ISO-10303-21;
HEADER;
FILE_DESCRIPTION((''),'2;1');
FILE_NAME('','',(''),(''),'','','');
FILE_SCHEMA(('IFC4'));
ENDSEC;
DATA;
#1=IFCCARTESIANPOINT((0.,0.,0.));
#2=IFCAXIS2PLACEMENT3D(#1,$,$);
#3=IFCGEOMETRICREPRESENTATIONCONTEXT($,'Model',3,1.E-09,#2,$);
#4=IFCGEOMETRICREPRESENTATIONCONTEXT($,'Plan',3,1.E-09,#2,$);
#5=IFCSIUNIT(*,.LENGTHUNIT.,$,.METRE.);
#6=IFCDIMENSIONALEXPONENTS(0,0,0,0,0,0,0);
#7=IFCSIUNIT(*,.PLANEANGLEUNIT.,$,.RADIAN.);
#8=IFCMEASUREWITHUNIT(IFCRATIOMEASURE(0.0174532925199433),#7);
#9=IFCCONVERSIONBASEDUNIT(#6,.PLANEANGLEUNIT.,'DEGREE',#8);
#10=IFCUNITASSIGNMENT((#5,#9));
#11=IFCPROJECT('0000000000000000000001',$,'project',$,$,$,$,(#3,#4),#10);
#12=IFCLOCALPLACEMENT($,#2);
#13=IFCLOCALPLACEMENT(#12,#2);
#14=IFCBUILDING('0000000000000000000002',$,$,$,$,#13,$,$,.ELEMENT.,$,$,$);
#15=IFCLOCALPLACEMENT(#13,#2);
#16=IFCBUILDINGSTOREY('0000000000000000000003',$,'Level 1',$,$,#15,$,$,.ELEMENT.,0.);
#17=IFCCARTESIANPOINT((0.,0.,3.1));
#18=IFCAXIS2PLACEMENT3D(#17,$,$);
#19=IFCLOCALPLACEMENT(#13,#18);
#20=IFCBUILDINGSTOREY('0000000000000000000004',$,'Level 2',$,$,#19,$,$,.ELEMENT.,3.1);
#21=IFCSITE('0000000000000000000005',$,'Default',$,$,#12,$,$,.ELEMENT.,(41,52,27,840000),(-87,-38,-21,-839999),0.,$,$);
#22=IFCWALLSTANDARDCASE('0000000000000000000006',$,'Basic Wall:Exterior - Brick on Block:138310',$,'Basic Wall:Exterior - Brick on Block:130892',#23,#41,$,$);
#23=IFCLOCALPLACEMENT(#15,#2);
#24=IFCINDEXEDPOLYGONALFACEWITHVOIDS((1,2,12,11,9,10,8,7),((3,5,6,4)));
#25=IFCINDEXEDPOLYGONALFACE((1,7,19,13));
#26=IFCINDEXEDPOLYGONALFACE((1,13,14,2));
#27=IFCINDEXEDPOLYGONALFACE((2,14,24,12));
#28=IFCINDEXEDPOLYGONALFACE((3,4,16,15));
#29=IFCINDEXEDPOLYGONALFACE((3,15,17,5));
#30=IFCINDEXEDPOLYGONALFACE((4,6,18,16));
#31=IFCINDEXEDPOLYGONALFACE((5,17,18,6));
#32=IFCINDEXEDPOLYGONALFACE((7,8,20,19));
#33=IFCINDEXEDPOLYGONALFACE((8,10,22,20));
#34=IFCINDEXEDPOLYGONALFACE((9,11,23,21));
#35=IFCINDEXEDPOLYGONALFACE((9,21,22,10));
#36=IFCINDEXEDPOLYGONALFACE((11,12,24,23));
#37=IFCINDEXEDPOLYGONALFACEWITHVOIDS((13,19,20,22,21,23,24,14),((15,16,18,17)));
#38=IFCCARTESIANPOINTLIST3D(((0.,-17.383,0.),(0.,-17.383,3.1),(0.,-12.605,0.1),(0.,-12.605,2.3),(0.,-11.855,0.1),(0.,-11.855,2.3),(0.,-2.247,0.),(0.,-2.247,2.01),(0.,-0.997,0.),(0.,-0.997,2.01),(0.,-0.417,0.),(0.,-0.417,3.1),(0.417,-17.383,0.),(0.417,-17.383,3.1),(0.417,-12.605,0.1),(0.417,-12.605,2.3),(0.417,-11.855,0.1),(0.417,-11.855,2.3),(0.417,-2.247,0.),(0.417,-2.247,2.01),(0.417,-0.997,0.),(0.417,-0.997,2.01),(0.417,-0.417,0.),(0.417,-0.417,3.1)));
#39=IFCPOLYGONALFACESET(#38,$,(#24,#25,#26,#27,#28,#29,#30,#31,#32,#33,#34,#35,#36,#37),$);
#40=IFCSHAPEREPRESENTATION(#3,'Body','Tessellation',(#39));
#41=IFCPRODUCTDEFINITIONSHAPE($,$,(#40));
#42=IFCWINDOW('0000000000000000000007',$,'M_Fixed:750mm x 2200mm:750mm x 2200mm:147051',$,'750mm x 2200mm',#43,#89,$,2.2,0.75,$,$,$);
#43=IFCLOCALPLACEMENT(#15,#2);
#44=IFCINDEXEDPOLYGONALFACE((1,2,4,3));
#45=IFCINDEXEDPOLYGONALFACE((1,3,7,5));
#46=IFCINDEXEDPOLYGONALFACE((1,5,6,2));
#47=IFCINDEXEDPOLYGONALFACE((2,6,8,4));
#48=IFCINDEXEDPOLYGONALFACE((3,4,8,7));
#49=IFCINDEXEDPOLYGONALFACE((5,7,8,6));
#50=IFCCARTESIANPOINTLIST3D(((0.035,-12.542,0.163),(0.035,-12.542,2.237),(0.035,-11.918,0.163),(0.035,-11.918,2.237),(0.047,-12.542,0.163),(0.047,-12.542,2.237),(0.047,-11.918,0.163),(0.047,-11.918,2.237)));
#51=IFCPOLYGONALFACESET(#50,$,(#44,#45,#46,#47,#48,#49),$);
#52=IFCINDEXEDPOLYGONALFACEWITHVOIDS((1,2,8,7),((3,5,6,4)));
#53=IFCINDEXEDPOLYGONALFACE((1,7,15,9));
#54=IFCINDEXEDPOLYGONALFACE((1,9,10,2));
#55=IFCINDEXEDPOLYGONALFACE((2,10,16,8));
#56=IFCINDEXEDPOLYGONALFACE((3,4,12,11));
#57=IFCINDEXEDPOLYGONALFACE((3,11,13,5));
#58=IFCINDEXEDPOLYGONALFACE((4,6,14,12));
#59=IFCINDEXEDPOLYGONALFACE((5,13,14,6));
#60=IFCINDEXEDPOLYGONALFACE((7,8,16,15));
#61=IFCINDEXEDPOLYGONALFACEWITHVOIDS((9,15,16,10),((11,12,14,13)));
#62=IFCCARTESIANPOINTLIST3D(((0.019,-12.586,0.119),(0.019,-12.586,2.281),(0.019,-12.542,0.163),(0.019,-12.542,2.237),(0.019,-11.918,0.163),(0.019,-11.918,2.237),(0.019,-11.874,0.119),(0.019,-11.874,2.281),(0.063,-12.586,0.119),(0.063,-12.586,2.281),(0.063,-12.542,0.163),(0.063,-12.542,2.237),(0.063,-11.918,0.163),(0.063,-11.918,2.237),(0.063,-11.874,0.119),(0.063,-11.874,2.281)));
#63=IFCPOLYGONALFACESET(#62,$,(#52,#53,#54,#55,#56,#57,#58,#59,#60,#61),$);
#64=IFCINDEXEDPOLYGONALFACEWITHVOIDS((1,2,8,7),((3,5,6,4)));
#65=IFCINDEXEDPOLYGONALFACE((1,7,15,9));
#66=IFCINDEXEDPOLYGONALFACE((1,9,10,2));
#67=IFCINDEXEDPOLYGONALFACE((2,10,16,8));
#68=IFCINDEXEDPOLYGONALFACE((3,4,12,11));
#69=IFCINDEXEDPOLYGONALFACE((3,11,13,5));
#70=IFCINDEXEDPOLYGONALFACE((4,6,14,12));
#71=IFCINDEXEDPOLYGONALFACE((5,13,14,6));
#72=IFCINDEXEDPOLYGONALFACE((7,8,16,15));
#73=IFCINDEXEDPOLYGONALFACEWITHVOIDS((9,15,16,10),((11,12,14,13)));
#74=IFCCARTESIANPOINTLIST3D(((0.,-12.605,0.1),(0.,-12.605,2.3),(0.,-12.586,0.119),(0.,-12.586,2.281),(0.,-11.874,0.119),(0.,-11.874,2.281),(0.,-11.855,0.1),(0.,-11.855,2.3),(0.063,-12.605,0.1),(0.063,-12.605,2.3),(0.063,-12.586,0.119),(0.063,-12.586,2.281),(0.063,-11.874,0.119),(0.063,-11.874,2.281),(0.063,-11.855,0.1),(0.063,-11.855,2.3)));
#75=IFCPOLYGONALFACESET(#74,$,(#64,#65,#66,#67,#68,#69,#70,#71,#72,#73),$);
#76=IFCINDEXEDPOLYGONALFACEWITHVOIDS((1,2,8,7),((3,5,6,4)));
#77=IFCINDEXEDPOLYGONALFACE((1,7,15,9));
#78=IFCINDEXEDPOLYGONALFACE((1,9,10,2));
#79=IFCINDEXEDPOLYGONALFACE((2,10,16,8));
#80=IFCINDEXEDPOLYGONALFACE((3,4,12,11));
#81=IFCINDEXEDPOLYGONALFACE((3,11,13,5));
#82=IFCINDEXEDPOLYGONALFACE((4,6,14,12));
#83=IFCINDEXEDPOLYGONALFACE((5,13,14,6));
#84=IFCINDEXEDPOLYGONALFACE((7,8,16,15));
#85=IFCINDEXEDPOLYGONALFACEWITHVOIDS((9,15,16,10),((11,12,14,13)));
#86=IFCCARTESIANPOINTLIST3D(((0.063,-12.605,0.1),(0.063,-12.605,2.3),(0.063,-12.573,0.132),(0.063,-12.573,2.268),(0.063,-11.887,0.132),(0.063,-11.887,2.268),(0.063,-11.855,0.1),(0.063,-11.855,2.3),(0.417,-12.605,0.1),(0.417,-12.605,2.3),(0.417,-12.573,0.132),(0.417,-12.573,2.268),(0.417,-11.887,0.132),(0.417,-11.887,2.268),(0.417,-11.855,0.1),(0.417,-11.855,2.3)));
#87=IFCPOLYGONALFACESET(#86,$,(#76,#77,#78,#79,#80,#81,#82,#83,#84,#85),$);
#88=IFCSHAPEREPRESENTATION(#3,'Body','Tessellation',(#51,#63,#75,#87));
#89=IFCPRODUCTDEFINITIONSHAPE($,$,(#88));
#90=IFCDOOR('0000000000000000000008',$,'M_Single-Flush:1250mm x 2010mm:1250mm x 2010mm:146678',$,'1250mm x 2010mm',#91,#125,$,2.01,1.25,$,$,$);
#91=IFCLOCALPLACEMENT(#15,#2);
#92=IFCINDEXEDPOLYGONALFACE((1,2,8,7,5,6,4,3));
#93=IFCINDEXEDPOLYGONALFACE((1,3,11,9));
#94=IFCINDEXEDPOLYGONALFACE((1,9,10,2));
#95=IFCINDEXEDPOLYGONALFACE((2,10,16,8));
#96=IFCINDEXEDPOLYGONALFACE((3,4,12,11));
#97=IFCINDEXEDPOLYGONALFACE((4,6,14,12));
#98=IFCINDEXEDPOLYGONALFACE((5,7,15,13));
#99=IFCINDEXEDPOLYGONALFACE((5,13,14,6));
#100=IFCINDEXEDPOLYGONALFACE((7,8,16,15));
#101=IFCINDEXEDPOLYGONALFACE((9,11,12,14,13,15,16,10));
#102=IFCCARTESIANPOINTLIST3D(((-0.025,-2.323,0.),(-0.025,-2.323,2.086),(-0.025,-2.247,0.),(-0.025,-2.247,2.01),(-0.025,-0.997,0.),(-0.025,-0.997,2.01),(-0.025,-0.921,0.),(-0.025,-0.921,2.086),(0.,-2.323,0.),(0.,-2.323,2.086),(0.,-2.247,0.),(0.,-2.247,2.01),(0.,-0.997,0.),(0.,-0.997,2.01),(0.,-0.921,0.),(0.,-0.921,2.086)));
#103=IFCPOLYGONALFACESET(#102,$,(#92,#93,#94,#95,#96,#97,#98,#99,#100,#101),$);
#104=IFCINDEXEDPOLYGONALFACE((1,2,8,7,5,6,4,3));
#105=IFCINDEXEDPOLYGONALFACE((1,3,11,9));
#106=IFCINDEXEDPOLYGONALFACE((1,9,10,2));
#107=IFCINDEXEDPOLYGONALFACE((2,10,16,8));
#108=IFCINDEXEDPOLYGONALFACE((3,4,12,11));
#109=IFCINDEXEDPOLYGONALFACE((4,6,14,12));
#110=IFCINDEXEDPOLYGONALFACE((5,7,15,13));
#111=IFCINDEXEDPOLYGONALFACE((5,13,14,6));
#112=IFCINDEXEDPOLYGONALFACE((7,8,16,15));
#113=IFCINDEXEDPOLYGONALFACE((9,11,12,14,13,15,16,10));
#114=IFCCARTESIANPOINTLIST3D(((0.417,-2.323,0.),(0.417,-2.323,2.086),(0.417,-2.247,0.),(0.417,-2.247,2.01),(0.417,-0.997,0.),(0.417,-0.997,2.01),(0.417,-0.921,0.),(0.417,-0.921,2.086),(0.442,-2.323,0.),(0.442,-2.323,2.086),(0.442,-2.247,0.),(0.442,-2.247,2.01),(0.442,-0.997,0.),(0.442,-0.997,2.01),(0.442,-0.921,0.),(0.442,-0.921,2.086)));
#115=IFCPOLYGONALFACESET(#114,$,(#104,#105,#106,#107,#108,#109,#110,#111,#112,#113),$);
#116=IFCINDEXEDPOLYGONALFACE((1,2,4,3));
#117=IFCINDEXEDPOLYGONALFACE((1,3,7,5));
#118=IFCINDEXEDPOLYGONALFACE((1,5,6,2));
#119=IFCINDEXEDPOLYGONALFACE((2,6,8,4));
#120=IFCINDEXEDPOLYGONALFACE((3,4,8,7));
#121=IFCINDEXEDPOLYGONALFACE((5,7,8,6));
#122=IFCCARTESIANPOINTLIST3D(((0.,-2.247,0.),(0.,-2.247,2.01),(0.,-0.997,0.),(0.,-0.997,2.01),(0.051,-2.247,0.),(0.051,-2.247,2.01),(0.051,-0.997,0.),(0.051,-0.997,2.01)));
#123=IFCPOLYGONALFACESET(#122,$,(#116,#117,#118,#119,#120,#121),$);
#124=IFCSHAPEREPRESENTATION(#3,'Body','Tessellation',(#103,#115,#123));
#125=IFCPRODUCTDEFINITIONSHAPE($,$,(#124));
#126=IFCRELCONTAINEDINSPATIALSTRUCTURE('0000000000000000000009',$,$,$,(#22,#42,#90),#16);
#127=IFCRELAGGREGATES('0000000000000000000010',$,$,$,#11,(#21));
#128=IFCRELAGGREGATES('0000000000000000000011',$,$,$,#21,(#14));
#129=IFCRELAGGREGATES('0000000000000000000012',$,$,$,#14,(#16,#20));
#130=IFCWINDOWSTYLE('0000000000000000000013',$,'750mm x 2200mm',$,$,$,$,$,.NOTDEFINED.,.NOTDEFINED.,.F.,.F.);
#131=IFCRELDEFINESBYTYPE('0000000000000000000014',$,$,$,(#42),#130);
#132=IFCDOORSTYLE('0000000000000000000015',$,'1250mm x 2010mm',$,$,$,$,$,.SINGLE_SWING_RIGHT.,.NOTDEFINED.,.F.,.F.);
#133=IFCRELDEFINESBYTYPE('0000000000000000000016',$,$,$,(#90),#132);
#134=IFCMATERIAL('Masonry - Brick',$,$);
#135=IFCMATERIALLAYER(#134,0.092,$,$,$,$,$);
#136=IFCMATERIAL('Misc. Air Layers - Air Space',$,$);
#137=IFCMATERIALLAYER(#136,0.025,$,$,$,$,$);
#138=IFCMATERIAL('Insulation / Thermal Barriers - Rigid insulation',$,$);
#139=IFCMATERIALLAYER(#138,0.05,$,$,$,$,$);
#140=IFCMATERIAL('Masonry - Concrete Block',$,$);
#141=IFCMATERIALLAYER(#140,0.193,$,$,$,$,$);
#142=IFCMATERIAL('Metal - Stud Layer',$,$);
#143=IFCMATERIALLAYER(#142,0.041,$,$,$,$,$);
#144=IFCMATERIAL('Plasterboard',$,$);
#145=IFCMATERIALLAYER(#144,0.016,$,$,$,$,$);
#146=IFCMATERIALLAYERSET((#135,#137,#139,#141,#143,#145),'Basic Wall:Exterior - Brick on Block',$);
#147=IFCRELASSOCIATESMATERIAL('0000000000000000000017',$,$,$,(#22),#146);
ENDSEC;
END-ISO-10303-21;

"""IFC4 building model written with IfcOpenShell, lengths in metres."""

from ifc_helpers import new_model, entity, si_unit, converted_unit, frame, frame_2d, origin, origin_2d_with_axis, place, context, project, spatial, polyline, rectangle, outline, extrude, source, transform, mapped, material, layer, layer_set, layer_usage, type_object, type_shapes, element, fill, save


model = new_model("IFC4")

# Units and contexts
model_context = context("Model", 3, precision=1e-09, world=origin())
plan_context = context("Plan", 3, precision=1e-09, world=origin())
ifc_project = project(units=[si_unit("LENGTHUNIT", "METRE"), converted_unit("PLANEANGLEUNIT", "DEGREE", entity("IfcRatioMeasure", 0.0174532925199433), si_unit("PLANEANGLEUNIT", "RADIAN"), dimensions=[0, 0, 0, 0, 0, 0, 0])], contexts=[model_context, plan_context])

# Site, building, storey
site_placement = place(None, origin())
site = spatial("IfcSite", under=ifc_project, at=site_placement, Name="Default", CompositionType="ELEMENT", RefLatitude=(41, 52, 27, 840000), RefLongitude=(-87, -38, -21, -839999), RefElevation=0.0)
building_placement = place(site_placement, origin())
building = spatial("IfcBuilding", under=site, at=building_placement, CompositionType="ELEMENT")
storey_1_placement = place(building_placement, origin())
storey_1 = spatial("IfcBuildingStorey", under=building, at=storey_1_placement, Name="Level 1", CompositionType="ELEMENT", Elevation=0.0)

# Shared definitions
ifc_material_1 = material(Name="Metal - Stud Layer")
ifc_material_2 = material(Name="Plasterboard")
ifc_material_3 = material(Name="Masonry - Concrete Block")
ifc_material_4 = material(Name="Misc. Air Layers - Air Space")

# Wall, openings, window, door
ifc_material_5 = material(Name="Masonry - Brick")
ifc_layer_1 = layer(ifc_material_5, 0.092)
ifc_layer_2 = layer(ifc_material_4, 0.025)
ifc_material_6 = material(Name="Insulation / Thermal Barriers - Rigid insulation")
ifc_layer_3 = layer(ifc_material_6, 0.05)
ifc_layer_4 = layer(ifc_material_3, 0.193)
ifc_layer_5 = layer(ifc_material_1, 0.041)
ifc_layer_6 = layer(ifc_material_2, 0.016)
ifc_layer_set_1 = layer_set([ifc_layer_1, ifc_layer_2, ifc_layer_3, ifc_layer_4, ifc_layer_5, ifc_layer_6], Name="Basic Wall:Exterior - Brick on Block")
ifc_layer_usage_1 = layer_usage(ifc_layer_set_1, "AXIS2", "NEGATIVE", 0.2085)
wall_1_placement = place(storey_1_placement, frame((0.2085, -17.383, 0.0), z_axis=(0.0, 0.0, 1.0), x_axis=(0.0, 1.0, 0.0)))
wall_1 = element("IfcWallStandardCase", 1, at=wall_1_placement, inside=storey_1, material=ifc_layer_usage_1, Name="Basic Wall:Exterior - Brick on Block:138310", ObjectType="Basic Wall:Exterior - Brick on Block:130892", context=model_context, shape_type="SweptSolid", body=[
    extrude(rectangle(XDim=16.966, YDim=0.417, at=frame_2d((8.483, 0.0), x_axis=(-1.0, 0.0))), origin(), (0.0, 0.0, 1.0), 3.1),
])
opening_1_placement = place(wall_1_placement, frame((4.778, -0.2085, 0.1)))
opening_1 = element("IfcOpeningElement", 2, at=opening_1_placement, cuts=wall_1, ObjectType="Opening", context=model_context, shape_type="SweptSolid", body=[
    extrude(rectangle(XDim=2.2, YDim=0.75, at=frame_2d((1.1, 0.375), x_axis=(1.0, 0.0))), frame((0.0, 0.0, 0.0), z_axis=(0.0, 1.0, 0.0), x_axis=(0.0, 0.0, 1.0)), (0.0, 0.0, 1.0), 0.417),
])
opening_2_placement = place(wall_1_placement, frame((15.136, -0.2085, 0.0)))
opening_2 = element("IfcOpeningElement", 3, at=opening_2_placement, cuts=wall_1, ObjectType="Opening", context=model_context, shape_type="SweptSolid", body=[
    extrude(rectangle(XDim=1.25, YDim=2.01, at=frame_2d((1.005, 0.625), x_axis=(0.0, 1.0))), frame((0.0, 0.0, 0.0), z_axis=(0.0, 1.0, 0.0), x_axis=(0.0, 0.0, 1.0)), (0.0, 0.0, 1.0), 0.417),
])
window_style_1 = type_object("IfcWindowStyle", Name="750mm x 2200mm", ConstructionType="NOTDEFINED", OperationType="NOTDEFINED", ParameterTakesPrecedence=False, Sizeable=False)
shared_shape_1 = source(origin(), model_context, "Body", "SweptSolid", [
    extrude(rectangle(XDim=0.012, YDim=0.624, at=origin_2d_with_axis()), frame((0.375, 0.376, 0.063), z_axis=(0.0, 0.0, 1.0), x_axis=(0.0, -1.0, 0.0)), (0.0, 0.0, 1.0), 2.074),
    extrude(outline(polyline([(-0.356, -1.081), (0.356, -1.081), (0.356, 1.081), (-0.356, 1.081), (-0.356, -1.081)]), holes=[polyline([(-0.312, -1.037), (-0.312, 1.037), (0.312, 1.037), (0.312, -1.037), (-0.312, -1.037)])]), frame((0.375, 0.354, 1.1), z_axis=(0.0, 1.0, 0.0), x_axis=(1.0, 0.0, 0.0)), (0.0, 0.0, 1.0), 0.044),
    extrude(outline(polyline([(-0.375, -1.1), (0.375, -1.1), (0.375, 1.1), (-0.375, 1.1), (-0.375, -1.1)]), holes=[polyline([(-0.356, -1.081), (-0.356, 1.081), (0.356, 1.081), (0.356, -1.081), (-0.356, -1.081)])]), frame((0.375, 0.354, 1.1), z_axis=(0.0, 1.0, 0.0), x_axis=(1.0, 0.0, 0.0)), (0.0, 0.0, 1.0), 0.063),
    extrude(outline(polyline([(-0.375, -1.1), (0.375, -1.1), (0.375, 1.1), (-0.375, 1.1), (-0.375, -1.1)]), holes=[polyline([(-0.343, -1.068), (-0.343, 1.068), (0.343, 1.068), (0.343, -1.068), (-0.343, -1.068)])]), frame((0.375, 0.0, 1.1), z_axis=(0.0, 1.0, 0.0), x_axis=(1.0, 0.0, 0.0)), (0.0, 0.0, 1.0), 0.354),
])
type_shapes(window_style_1, [shared_shape_1])
window_1_placement = place(opening_1_placement, origin())
window_1 = element("IfcWindow", 4, at=window_1_placement, inside=storey_1, type_object=window_style_1, Name="M_Fixed:750mm x 2200mm:750mm x 2200mm:147051", ObjectType="750mm x 2200mm", OverallHeight=2.2, OverallWidth=0.75, context=model_context, shape_type="MappedRepresentation", body=[
    mapped(shared_shape_1, transform((0.0, 0.0, 0.0), scale=1.0)),
])
fill(opening_1, window_1)
door_style_1 = type_object("IfcDoorStyle", Name="1250mm x 2010mm", ConstructionType="NOTDEFINED", OperationType="SINGLE_SWING_RIGHT", ParameterTakesPrecedence=False, Sizeable=False)
shared_shape_2 = source(origin(), model_context, "Body", "SweptSolid", [
    extrude(outline(polyline([(-0.701, -1.062), (0.701, -1.062), (0.701, 1.024), (0.625, 1.024), (0.625, -0.986), (-0.625, -0.986), (-0.625, 1.024), (-0.701, 1.024), (-0.701, -1.062)])), frame((0.625, 0.417, 1.024), z_axis=(0.0, 1.0, 0.0), x_axis=(1.0, 0.0, 0.0)), (0.0, 0.0, 1.0), 0.025),
    extrude(outline(polyline([(-1.062, -0.701), (1.024, -0.701), (1.024, -0.625), (-0.986, -0.625), (-0.986, 0.625), (1.024, 0.625), (1.024, 0.701), (-1.062, 0.701), (-1.062, -0.701)])), frame((0.625, -0.025, 1.024), z_axis=(0.0, 1.0, 0.0), x_axis=(0.0, 0.0, -1.0)), (0.0, 0.0, 1.0), 0.025),
    extrude(rectangle(XDim=0.051, YDim=1.25, at=origin_2d_with_axis()), frame((0.625, 0.3915, 0.0), z_axis=(0.0, 0.0, 1.0), x_axis=(0.0, 1.0, 0.0)), (0.0, 0.0, 1.0), 2.01),
])
type_shapes(door_style_1, [shared_shape_2])
door_1_placement = place(opening_2_placement, origin())
door_1 = element("IfcDoor", 5, at=door_1_placement, inside=storey_1, type_object=door_style_1, Name="M_Single-Flush:1250mm x 2010mm:1250mm x 2010mm:146678", ObjectType="1250mm x 2010mm", OverallHeight=2.01, OverallWidth=1.25, context=model_context, shape_type="MappedRepresentation", body=[
    mapped(shared_shape_2, transform((0.0, 0.0, 0.0), scale=1.0)),
])
fill(opening_2, door_1)

# Shared definitions
storey_2_placement = place(building_placement, frame((0.0, 0.0, 3.1)))
storey_2 = spatial("IfcBuildingStorey", under=building, at=storey_2_placement, Name="Level 2", CompositionType="ELEMENT", Elevation=3.1)

save(model, "model.ifc")
